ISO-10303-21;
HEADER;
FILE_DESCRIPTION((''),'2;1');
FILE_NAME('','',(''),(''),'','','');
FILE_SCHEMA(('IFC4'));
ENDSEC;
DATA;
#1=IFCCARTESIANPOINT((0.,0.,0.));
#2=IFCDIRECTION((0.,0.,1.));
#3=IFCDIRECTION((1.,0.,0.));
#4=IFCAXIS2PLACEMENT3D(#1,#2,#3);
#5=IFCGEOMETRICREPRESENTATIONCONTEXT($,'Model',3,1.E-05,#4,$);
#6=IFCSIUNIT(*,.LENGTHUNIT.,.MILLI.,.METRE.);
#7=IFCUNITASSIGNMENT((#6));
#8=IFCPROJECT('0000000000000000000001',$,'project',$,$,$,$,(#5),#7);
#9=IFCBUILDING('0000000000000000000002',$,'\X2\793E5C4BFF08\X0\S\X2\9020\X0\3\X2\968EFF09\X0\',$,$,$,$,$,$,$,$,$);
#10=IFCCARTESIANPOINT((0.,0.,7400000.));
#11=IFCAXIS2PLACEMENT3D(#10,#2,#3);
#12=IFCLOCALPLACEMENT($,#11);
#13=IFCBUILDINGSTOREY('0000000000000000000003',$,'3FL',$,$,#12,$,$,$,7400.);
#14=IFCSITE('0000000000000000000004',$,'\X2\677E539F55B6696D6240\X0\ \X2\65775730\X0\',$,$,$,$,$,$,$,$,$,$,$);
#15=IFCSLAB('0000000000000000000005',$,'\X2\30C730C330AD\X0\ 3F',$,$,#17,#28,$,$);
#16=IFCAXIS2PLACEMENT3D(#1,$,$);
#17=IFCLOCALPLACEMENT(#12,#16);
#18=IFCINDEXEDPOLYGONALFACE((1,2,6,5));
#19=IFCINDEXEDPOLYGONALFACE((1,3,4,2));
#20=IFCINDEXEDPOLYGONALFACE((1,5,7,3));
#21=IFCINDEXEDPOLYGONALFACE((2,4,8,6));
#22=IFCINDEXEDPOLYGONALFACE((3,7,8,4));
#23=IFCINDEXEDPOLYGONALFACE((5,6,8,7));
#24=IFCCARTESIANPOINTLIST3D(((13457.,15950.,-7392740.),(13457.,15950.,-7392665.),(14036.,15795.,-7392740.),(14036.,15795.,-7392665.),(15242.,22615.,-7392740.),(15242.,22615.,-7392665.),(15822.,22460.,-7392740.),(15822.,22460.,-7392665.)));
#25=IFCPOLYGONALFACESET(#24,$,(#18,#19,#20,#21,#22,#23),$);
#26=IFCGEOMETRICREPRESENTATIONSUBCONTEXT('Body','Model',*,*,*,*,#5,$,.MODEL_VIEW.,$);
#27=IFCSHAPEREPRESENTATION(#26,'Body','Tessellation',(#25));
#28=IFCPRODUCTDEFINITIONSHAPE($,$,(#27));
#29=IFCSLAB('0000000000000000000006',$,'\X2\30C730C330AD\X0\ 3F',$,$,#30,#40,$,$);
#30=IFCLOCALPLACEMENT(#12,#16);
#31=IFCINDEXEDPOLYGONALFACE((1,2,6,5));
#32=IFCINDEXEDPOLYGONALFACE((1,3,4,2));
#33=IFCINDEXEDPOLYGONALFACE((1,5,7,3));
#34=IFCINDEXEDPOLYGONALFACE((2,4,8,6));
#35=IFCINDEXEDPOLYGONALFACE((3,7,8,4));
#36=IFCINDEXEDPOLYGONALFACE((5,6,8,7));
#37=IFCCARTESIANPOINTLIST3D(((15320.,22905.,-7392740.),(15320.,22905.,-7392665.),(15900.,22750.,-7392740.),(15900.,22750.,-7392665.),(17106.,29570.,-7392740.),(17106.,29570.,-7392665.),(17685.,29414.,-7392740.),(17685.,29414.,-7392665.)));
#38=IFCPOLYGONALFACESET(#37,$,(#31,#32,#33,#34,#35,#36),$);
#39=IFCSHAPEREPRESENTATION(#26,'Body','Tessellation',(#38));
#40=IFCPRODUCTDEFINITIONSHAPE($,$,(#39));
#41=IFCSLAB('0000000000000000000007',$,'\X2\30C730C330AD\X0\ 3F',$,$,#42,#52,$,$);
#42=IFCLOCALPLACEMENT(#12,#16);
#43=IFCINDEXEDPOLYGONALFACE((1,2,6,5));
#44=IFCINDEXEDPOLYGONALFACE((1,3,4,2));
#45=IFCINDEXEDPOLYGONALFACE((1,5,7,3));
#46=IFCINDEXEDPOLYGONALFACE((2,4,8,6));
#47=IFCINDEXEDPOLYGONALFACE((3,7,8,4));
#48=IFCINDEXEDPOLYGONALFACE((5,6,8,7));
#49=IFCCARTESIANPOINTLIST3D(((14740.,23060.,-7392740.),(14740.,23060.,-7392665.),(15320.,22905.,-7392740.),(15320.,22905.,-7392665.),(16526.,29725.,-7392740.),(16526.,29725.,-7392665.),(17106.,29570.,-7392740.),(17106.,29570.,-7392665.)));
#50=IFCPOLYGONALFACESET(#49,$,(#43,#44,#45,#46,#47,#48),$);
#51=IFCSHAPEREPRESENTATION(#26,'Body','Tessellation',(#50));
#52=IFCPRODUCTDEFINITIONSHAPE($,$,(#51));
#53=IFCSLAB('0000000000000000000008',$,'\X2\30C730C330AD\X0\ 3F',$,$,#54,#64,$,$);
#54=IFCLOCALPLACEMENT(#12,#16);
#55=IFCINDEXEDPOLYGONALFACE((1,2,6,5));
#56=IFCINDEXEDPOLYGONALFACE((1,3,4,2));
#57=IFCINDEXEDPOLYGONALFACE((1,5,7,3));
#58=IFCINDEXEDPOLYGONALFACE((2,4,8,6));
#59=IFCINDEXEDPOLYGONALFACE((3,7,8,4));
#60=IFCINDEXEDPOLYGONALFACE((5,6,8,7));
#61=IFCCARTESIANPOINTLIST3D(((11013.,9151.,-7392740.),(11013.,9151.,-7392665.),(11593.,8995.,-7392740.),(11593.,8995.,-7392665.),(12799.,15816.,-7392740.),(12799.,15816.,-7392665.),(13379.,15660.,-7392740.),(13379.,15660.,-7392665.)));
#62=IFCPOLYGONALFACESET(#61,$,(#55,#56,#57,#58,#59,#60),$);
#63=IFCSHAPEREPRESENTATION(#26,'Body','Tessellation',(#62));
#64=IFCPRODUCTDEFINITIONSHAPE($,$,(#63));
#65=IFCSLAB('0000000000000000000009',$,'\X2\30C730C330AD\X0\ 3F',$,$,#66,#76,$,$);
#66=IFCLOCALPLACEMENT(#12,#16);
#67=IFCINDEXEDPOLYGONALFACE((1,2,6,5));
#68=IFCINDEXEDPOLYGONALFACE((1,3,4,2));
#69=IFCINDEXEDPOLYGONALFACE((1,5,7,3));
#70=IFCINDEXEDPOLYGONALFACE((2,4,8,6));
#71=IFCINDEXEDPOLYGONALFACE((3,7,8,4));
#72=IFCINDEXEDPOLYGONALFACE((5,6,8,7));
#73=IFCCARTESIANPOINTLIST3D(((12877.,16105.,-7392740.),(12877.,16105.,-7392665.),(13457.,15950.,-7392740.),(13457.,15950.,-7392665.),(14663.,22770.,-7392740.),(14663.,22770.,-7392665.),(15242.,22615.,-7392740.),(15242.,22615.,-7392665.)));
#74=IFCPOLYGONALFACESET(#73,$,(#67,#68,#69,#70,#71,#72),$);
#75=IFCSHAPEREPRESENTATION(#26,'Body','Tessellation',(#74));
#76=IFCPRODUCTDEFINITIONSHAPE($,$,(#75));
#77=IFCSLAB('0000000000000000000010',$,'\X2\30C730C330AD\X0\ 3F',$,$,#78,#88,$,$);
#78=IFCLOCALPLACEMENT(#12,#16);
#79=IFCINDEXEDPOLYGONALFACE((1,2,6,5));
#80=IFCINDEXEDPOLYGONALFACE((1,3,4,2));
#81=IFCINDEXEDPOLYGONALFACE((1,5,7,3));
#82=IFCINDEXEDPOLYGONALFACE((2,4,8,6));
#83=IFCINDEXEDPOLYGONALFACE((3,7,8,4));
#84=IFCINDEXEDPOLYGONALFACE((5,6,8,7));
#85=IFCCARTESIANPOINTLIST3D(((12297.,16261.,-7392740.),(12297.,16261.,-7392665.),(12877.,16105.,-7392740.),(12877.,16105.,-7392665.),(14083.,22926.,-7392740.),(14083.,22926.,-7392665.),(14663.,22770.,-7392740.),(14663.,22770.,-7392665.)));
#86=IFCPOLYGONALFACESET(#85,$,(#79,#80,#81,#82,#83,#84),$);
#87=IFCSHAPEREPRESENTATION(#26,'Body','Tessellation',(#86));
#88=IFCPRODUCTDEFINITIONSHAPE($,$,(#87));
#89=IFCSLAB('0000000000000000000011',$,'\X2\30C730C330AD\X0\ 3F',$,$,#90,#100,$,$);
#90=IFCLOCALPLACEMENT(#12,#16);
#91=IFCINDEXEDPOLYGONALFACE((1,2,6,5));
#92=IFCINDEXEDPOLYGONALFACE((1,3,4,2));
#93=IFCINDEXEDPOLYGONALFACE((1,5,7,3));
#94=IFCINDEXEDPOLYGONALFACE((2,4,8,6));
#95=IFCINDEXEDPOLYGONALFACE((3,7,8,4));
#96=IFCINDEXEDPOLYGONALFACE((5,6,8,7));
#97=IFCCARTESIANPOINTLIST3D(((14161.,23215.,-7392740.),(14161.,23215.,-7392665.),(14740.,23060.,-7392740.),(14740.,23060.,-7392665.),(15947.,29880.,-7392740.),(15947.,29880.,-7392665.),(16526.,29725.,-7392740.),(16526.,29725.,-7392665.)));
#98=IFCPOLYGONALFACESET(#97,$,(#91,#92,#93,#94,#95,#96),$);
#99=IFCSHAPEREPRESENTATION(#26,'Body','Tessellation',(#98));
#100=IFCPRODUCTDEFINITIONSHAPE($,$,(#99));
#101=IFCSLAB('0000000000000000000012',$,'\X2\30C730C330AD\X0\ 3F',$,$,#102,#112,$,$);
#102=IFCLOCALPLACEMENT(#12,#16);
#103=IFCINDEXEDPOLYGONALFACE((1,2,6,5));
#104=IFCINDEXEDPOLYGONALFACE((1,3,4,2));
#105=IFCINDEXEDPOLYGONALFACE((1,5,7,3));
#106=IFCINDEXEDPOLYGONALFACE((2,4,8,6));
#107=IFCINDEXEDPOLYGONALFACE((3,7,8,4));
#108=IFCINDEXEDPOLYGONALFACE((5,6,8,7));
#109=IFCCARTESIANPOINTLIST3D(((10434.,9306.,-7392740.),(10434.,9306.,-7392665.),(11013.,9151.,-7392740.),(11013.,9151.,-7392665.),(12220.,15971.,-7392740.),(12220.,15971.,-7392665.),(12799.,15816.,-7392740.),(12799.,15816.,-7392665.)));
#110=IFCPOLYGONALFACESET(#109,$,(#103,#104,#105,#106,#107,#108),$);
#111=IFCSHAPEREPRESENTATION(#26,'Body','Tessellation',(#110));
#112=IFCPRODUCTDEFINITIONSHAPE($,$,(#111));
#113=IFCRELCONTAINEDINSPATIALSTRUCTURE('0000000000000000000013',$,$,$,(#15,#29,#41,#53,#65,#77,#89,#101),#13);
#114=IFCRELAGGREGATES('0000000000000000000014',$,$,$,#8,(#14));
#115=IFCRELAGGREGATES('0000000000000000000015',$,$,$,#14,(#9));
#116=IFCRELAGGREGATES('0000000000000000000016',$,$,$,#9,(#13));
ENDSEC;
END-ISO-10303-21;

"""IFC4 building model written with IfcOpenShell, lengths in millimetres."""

from ifc_helpers import new_model, si_unit, frame, origin, origin_with_axes, place, context, subcontext, project, spatial, polyline, outline, extrude, element, save


model = new_model("IFC4")

# Units and contexts
model_context = context("Model", 3, precision=1e-05, world=origin_with_axes())
body_context = subcontext(model_context, "Body", "Model", "MODEL_VIEW")
ifc_project = project(units=[si_unit("LENGTHUNIT", "METRE", prefix="MILLI")], contexts=[model_context])

# Site, building, storey
site = spatial("IfcSite", under=ifc_project, Name="松原営業所 敷地")
building = spatial("IfcBuilding", under=site, Name="社屋（S造3階）")
storey_placement = place(None, frame((0.0, 0.0, 7400000.0), z_axis=(0.0, 0.0, 1.0), x_axis=(1.0, 0.0, 0.0)))
storey = spatial("IfcBuildingStorey", under=building, at=storey_placement, Name="3FL", Elevation=7400.0)

# Slabs
slab_1_placement = place(storey_placement, frame((0.0, 0.0, -7392740.0), z_axis=(0.0, 0.0, 1.0), x_axis=(1.0, 0.0, 0.0)))
element("IfcSlab", 1, at=slab_1_placement, inside=storey, Name="デッキ 3F", context=body_context, shape_type="SweptSolid", body=[
    extrude(outline(polyline([(14036.0, 15795.0), (15822.0, 22460.0), (15242.0, 22615.0), (13457.0, 15950.0), (14036.0, 15795.0)])), origin(), (0.0, 0.0, 1.0), 75.0),
])
slab_2_placement = place(storey_placement, frame((0.0, 0.0, -7392740.0), z_axis=(0.0, 0.0, 1.0), x_axis=(1.0, 0.0, 0.0)))
element("IfcSlab", 2, at=slab_2_placement, inside=storey, Name="デッキ 3F", context=body_context, shape_type="SweptSolid", body=[
    extrude(outline(polyline([(15900.0, 22750.0), (17685.0, 29414.0), (17106.0, 29570.0), (15320.0, 22905.0), (15900.0, 22750.0)])), origin(), (0.0, 0.0, 1.0), 75.0),
])
slab_3_placement = place(storey_placement, frame((0.0, 0.0, -7392740.0), z_axis=(0.0, 0.0, 1.0), x_axis=(1.0, 0.0, 0.0)))
element("IfcSlab", 3, at=slab_3_placement, inside=storey, Name="デッキ 3F", context=body_context, shape_type="SweptSolid", body=[
    extrude(outline(polyline([(15320.0, 22905.0), (17106.0, 29570.0), (16526.0, 29725.0), (14740.0, 23060.0), (15320.0, 22905.0)])), origin(), (0.0, 0.0, 1.0), 75.0),
])
slab_4_placement = place(storey_placement, frame((0.0, 0.0, -7392740.0), z_axis=(0.0, 0.0, 1.0), x_axis=(1.0, 0.0, 0.0)))
element("IfcSlab", 4, at=slab_4_placement, inside=storey, Name="デッキ 3F", context=body_context, shape_type="SweptSolid", body=[
    extrude(outline(polyline([(11593.0, 8995.0), (13379.0, 15660.0), (12799.0, 15816.0), (11013.0, 9151.0), (11593.0, 8995.0)])), origin(), (0.0, 0.0, 1.0), 75.0),
])
slab_5_placement = place(storey_placement, frame((0.0, 0.0, -7392740.0), z_axis=(0.0, 0.0, 1.0), x_axis=(1.0, 0.0, 0.0)))
element("IfcSlab", 5, at=slab_5_placement, inside=storey, Name="デッキ 3F", context=body_context, shape_type="SweptSolid", body=[
    extrude(outline(polyline([(13457.0, 15950.0), (15242.0, 22615.0), (14663.0, 22770.0), (12877.0, 16105.0), (13457.0, 15950.0)])), origin(), (0.0, 0.0, 1.0), 75.0),
])
slab_6_placement = place(storey_placement, frame((0.0, 0.0, -7392740.0), z_axis=(0.0, 0.0, 1.0), x_axis=(1.0, 0.0, 0.0)))
element("IfcSlab", 6, at=slab_6_placement, inside=storey, Name="デッキ 3F", context=body_context, shape_type="SweptSolid", body=[
    extrude(outline(polyline([(12877.0, 16105.0), (14663.0, 22770.0), (14083.0, 22926.0), (12297.0, 16261.0), (12877.0, 16105.0)])), origin(), (0.0, 0.0, 1.0), 75.0),
])
slab_7_placement = place(storey_placement, frame((0.0, 0.0, -7392740.0), z_axis=(0.0, 0.0, 1.0), x_axis=(1.0, 0.0, 0.0)))
element("IfcSlab", 7, at=slab_7_placement, inside=storey, Name="デッキ 3F", context=body_context, shape_type="SweptSolid", body=[
    extrude(outline(polyline([(14740.0, 23060.0), (16526.0, 29725.0), (15947.0, 29880.0), (14161.0, 23215.0), (14740.0, 23060.0)])), origin(), (0.0, 0.0, 1.0), 75.0),
])
slab_8_placement = place(storey_placement, frame((0.0, 0.0, -7392740.0), z_axis=(0.0, 0.0, 1.0), x_axis=(1.0, 0.0, 0.0)))
element("IfcSlab", 8, at=slab_8_placement, inside=storey, Name="デッキ 3F", context=body_context, shape_type="SweptSolid", body=[
    extrude(outline(polyline([(11013.0, 9151.0), (12799.0, 15816.0), (12220.0, 15971.0), (10434.0, 9306.0), (11013.0, 9151.0)])), origin(), (0.0, 0.0, 1.0), 75.0),
])

save(model, "model.ifc")
